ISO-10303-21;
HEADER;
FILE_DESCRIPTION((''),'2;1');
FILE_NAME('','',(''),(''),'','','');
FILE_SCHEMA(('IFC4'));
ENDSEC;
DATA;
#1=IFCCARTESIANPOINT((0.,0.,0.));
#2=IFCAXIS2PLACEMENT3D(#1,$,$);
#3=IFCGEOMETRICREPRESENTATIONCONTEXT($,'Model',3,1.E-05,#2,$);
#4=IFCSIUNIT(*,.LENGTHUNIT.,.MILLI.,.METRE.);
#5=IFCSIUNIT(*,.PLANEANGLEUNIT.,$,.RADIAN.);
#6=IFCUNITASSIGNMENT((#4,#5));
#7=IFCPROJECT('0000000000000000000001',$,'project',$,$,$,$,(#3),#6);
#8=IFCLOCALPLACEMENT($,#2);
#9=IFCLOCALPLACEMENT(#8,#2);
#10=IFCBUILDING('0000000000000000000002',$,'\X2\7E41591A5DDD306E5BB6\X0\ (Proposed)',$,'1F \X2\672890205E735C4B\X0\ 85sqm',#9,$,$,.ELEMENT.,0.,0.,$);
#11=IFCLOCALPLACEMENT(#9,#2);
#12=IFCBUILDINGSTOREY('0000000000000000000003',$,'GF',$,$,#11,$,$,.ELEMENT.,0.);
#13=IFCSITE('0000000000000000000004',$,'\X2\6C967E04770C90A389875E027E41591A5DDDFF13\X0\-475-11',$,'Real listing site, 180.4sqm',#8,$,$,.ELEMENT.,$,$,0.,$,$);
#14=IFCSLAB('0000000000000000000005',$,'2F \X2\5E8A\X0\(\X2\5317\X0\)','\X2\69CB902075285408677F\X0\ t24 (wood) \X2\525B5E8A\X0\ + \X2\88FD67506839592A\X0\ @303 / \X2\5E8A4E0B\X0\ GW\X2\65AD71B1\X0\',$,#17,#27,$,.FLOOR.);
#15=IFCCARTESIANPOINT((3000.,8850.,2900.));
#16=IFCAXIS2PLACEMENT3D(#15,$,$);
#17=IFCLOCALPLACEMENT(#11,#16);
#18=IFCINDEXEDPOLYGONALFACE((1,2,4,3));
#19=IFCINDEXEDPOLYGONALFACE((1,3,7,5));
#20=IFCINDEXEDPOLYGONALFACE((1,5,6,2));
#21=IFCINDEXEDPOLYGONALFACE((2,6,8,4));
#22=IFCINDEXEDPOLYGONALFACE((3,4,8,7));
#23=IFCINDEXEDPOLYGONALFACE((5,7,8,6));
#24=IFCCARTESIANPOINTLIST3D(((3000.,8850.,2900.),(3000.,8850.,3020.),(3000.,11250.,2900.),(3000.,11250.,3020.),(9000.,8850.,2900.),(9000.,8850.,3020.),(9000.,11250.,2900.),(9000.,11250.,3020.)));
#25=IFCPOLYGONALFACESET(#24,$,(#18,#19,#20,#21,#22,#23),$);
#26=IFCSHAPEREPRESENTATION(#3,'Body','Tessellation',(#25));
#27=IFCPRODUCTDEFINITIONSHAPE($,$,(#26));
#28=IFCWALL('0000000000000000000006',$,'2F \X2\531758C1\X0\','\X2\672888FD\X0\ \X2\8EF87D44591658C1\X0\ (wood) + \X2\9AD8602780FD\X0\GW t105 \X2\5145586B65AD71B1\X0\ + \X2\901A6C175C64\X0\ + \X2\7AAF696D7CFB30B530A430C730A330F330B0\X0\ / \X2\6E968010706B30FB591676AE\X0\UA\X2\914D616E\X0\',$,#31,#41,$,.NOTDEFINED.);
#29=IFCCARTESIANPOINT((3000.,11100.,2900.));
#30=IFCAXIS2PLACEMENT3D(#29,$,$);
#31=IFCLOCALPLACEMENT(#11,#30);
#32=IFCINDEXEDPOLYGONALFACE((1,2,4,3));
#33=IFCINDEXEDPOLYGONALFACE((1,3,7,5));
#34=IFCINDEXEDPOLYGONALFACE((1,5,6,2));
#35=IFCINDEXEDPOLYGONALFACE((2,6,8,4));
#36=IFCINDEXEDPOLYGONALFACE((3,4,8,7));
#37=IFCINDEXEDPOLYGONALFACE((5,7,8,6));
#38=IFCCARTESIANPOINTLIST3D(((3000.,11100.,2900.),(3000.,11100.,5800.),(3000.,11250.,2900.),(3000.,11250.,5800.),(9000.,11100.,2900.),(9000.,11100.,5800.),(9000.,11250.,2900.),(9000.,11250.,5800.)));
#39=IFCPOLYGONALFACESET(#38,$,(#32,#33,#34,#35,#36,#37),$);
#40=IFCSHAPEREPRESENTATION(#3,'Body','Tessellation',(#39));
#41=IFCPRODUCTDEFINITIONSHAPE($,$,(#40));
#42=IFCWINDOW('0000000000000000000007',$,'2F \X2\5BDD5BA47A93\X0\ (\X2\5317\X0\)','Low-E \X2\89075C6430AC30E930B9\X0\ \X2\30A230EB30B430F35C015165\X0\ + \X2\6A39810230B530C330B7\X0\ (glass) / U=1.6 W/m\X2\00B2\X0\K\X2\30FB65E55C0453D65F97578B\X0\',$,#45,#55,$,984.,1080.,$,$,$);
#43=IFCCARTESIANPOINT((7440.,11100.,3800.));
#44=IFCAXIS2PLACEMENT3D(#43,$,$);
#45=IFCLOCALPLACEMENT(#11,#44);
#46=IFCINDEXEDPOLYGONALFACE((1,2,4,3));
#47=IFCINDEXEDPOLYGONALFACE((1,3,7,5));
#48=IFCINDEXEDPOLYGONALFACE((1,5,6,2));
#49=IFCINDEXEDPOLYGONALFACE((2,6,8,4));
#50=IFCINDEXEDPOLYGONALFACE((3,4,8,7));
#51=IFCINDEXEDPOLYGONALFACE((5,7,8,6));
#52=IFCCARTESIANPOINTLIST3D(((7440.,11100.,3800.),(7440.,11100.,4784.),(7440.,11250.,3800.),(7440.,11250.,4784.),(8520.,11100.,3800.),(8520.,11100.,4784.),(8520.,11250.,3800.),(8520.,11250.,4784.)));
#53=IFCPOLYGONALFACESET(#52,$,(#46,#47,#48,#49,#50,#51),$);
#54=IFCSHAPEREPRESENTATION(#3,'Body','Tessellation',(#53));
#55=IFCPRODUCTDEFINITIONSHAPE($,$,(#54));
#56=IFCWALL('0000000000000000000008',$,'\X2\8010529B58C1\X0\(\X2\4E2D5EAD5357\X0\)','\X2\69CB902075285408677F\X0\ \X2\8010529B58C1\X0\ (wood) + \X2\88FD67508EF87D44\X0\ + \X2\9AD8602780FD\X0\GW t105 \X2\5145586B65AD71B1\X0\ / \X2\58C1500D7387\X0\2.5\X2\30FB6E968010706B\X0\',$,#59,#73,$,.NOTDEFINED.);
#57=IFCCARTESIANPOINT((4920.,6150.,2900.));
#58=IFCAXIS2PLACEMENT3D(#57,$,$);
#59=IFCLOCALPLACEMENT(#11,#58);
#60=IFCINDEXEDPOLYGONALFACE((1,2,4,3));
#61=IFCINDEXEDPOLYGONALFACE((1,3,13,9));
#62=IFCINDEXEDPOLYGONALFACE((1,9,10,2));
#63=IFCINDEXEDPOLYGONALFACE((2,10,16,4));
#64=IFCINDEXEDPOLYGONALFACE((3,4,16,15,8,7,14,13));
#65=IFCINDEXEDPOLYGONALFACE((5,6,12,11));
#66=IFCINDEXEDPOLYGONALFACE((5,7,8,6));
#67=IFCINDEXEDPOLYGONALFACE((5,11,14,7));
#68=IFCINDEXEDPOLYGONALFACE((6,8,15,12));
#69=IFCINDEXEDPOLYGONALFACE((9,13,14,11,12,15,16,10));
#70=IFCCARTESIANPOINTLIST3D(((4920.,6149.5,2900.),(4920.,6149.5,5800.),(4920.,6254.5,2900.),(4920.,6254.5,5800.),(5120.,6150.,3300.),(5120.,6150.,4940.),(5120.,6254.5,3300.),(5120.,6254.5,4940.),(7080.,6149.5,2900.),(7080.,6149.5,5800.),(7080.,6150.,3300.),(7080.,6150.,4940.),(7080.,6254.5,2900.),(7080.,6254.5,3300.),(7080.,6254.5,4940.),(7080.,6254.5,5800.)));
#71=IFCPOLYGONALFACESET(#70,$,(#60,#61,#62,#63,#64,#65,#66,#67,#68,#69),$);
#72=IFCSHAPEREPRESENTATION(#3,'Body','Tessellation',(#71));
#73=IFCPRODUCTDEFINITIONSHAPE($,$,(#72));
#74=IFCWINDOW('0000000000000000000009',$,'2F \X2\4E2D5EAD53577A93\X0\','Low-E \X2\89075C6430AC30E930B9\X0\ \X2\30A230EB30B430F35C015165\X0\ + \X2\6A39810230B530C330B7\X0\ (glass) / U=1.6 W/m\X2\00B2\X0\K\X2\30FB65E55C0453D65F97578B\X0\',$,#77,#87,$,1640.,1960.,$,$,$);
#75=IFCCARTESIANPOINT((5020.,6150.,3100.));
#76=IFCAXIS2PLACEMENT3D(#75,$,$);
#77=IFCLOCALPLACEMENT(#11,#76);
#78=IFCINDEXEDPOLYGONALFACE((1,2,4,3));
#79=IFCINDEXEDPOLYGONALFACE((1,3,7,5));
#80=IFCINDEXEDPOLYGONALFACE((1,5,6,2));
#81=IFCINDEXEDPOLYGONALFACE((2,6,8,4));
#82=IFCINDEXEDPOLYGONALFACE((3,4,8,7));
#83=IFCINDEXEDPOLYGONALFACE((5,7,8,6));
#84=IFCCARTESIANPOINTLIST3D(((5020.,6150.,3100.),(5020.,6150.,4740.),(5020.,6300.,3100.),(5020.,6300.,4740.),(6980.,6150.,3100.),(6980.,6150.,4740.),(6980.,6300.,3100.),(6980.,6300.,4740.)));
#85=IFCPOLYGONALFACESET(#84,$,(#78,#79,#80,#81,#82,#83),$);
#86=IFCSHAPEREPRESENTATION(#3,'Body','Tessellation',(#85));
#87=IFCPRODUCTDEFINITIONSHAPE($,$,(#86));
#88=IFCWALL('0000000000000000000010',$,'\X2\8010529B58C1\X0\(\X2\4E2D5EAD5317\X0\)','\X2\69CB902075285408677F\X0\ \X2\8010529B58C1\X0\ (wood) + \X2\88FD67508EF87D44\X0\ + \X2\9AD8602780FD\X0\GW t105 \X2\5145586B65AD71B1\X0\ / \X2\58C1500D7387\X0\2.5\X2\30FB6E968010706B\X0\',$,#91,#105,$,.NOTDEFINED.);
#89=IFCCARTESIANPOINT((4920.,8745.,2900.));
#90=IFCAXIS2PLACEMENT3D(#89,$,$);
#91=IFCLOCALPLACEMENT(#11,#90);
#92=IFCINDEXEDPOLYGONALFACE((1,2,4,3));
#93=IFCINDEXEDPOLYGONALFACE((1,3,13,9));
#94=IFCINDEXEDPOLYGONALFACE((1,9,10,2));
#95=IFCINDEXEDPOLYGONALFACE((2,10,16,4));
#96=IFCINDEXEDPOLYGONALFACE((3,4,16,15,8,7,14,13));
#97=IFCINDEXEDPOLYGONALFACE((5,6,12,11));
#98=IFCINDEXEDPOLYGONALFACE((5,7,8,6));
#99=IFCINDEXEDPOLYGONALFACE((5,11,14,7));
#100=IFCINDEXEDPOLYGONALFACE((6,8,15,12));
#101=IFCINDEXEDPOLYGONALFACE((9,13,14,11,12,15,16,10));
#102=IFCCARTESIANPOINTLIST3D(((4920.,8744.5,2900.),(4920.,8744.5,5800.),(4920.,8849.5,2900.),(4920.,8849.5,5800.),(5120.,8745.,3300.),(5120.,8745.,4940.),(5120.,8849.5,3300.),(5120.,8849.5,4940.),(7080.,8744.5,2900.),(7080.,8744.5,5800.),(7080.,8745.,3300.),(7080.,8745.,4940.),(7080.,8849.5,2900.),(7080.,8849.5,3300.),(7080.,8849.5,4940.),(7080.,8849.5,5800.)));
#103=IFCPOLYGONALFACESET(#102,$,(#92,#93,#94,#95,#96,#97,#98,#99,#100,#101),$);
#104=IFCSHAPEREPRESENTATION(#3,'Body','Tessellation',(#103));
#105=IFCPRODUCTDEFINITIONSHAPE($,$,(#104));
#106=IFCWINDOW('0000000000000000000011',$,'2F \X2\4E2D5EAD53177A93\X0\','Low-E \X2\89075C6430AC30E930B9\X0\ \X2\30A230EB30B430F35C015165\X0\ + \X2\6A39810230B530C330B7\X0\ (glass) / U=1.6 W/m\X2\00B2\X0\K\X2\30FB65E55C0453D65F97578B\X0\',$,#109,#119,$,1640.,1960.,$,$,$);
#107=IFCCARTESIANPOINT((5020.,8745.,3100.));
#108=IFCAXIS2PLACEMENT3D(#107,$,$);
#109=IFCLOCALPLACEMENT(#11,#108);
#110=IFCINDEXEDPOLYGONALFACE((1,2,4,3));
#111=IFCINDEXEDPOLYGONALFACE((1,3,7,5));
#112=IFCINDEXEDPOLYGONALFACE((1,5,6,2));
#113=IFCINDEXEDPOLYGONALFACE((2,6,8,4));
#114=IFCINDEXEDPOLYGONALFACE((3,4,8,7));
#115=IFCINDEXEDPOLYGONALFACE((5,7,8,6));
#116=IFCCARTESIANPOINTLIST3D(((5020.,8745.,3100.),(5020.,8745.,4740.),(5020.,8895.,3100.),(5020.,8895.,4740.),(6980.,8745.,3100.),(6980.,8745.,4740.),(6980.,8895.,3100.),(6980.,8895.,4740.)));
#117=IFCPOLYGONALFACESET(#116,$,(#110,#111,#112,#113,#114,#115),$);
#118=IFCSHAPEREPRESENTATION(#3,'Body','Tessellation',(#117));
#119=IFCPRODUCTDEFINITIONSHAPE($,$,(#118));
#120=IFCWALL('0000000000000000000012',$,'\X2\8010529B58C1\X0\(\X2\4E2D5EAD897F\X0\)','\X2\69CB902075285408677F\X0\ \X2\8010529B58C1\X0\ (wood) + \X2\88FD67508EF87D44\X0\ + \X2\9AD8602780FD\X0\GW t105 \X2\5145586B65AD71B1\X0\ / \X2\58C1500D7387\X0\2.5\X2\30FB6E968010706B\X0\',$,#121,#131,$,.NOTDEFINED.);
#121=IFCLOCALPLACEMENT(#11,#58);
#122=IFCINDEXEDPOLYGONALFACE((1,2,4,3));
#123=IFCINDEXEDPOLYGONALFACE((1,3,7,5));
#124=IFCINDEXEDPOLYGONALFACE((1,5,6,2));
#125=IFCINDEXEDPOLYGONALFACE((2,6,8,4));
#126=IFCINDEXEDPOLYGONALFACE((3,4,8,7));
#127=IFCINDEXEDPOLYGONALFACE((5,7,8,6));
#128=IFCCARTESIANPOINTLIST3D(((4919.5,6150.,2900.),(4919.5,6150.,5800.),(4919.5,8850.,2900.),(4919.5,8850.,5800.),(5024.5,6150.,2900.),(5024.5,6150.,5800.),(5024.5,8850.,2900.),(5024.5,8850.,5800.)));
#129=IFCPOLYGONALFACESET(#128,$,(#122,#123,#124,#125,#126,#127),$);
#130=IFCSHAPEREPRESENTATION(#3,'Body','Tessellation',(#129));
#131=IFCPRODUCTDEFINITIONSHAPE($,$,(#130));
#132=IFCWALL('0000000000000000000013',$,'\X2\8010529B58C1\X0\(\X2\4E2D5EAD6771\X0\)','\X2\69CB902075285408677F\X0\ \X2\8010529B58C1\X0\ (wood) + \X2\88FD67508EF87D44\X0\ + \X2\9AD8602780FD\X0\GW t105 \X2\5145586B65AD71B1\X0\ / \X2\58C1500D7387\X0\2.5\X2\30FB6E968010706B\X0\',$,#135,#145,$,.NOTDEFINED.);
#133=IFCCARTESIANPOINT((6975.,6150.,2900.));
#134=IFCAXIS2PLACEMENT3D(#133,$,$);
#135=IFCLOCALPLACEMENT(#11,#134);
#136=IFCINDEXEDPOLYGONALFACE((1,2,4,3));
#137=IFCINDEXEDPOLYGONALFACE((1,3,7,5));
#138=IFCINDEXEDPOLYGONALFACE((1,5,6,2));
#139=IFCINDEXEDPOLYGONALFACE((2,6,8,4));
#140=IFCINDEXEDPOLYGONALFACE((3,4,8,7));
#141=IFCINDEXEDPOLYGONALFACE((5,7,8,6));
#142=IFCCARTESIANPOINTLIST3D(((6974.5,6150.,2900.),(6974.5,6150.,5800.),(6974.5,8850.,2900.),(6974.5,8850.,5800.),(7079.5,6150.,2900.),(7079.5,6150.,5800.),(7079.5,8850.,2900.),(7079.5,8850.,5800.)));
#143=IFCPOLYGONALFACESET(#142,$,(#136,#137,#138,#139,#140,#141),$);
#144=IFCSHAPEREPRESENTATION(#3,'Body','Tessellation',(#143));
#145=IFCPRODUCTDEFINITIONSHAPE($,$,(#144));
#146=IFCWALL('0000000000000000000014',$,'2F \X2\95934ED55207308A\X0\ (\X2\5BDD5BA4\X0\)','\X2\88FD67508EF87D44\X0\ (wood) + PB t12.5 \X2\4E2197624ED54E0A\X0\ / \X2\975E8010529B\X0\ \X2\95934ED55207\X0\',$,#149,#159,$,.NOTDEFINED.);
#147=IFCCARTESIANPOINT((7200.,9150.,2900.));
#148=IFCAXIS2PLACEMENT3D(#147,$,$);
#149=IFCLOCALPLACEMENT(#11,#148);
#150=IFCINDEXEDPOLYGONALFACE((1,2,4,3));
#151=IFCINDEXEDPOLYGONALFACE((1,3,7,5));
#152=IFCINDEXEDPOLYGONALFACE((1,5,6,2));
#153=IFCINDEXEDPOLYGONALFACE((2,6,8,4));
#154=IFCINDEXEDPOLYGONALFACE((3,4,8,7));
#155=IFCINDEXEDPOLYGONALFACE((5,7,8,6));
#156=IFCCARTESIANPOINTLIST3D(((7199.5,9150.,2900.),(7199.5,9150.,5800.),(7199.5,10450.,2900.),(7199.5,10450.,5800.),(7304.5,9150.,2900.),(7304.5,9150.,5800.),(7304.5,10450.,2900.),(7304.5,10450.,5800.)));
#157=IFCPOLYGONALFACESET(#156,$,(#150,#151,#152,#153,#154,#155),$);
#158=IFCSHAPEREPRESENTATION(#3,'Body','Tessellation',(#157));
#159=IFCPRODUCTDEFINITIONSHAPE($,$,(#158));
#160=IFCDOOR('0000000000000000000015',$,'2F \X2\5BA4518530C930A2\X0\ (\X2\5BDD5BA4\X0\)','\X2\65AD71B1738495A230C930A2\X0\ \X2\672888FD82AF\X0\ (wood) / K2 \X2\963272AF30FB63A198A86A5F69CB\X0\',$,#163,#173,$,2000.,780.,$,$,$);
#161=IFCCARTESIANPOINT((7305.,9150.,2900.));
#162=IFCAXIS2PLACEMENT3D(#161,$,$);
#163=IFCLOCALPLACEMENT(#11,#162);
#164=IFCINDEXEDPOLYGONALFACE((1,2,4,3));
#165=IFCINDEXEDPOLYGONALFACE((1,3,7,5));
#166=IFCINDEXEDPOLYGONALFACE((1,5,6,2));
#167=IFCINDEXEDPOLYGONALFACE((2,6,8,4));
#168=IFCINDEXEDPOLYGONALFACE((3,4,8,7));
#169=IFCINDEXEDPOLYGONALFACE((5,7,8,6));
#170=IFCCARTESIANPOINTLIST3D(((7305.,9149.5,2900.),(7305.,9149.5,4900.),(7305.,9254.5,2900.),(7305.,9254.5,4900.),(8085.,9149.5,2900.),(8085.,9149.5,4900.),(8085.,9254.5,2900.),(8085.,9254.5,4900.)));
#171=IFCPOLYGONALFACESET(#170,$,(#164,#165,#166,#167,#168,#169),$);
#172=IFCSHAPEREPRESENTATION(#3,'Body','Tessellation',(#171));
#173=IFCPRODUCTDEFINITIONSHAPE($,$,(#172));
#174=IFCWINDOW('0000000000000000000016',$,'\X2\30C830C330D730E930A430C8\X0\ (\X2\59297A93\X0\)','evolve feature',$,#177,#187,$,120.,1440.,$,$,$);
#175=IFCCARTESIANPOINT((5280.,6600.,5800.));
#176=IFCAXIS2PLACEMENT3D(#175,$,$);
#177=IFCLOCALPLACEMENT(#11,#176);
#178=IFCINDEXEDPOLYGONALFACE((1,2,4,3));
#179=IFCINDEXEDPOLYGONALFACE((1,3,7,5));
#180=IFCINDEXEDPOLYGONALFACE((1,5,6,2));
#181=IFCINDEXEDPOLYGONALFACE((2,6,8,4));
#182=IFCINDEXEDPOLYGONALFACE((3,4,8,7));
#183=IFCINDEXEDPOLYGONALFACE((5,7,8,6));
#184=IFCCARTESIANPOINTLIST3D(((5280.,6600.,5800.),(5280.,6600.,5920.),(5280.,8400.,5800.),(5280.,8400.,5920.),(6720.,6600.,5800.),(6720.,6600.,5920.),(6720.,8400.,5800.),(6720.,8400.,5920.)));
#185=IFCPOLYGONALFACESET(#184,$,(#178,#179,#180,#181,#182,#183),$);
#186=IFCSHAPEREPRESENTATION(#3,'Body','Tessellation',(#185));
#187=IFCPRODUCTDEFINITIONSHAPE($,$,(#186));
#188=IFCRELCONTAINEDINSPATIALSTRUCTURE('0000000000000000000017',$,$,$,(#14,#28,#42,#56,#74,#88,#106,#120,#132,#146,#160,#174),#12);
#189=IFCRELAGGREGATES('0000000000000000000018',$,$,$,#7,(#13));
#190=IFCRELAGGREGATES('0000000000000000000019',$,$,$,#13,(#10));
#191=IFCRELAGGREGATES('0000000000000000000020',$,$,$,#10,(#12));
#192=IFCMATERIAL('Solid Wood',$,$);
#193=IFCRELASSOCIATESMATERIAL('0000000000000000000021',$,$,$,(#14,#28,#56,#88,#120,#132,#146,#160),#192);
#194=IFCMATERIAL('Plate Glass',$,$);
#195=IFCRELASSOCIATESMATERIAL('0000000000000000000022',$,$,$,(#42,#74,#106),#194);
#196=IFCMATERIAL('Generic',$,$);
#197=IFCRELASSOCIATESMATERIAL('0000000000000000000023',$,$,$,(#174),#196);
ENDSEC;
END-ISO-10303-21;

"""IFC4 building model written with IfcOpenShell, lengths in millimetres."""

from ifc_helpers import new_model, si_unit, frame, frame_2d, origin, place, context, project, spatial, rectangle, extrude, material, element, fill, save


model = new_model("IFC4")

# Units and contexts
model_context = context("Model", 3, precision=1e-05, world=origin())
ifc_project = project(units=[si_unit("LENGTHUNIT", "METRE", prefix="MILLI"), si_unit("PLANEANGLEUNIT", "RADIAN")], contexts=[model_context])

# Site, building, storey
site_placement = place(None, origin())
site = spatial("IfcSite", under=ifc_project, at=site_placement, Name="沖縄県那覇市繁多川３-475-11", ObjectType="Real listing site, 180.4sqm", CompositionType="ELEMENT", RefElevation=0.0)
building_placement = place(site_placement, origin())
building = spatial("IfcBuilding", under=site, at=building_placement, Name="繁多川の家 (Proposed)", ObjectType="1F 木造平屋 85sqm", CompositionType="ELEMENT", ElevationOfRefHeight=0.0, ElevationOfTerrain=0.0)
storey_placement = place(building_placement, origin())
storey = spatial("IfcBuildingStorey", under=building, at=storey_placement, Name="GF", CompositionType="ELEMENT", Elevation=0.0)

# Slab
ifc_material_1 = material(Name="Solid Wood")
slab_placement = place(storey_placement, frame((3000.0, 8850.0, 2900.0)))
element("IfcSlab", 1, at=slab_placement, inside=storey, material=ifc_material_1, Name="2F 床(北)", Description="構造用合板 t24 (wood) 剛床 + 製材根太 @303 / 床下 GW断熱", PredefinedType="FLOOR", context=model_context, shape_type="SweptSolid", body=[
    extrude(rectangle(XDim=6000.0, YDim=2400.0, at=frame_2d((3000.0, 1200.0))), frame((3000.0, 8850.0, 2900.0)), (0.0, 0.0, 1.0), 120.0),
])

# Walls, openings, windows
wall_1_placement = place(storey_placement, frame((3000.0, 11100.0, 2900.0)))
wall_1 = element("IfcWall", 2, at=wall_1_placement, inside=storey, material=ifc_material_1, Name="2F 北壁", Description="木製 軸組外壁 (wood) + 高性能GW t105 充填断熱 + 通気層 + 窯業系サイディング / 準耐火・外皮UA配慮", PredefinedType="NOTDEFINED", context=model_context, shape_type="SweptSolid", body=[
    extrude(rectangle(XDim=6000.0, YDim=150.0, at=frame_2d((3000.0, 75.0))), frame((3000.0, 11100.0, 2900.0)), (0.0, 0.0, 1.0), 2900.0),
])
opening_1_placement = place(storey_placement, frame((7440.0, 11100.0, 3800.0)))
opening_1 = element("IfcOpeningElement", 3, at=opening_1_placement, cuts=wall_1, PredefinedType="NOTDEFINED", context=model_context, shape_type="SweptSolid", body=[
    extrude(rectangle(XDim=1080.0, YDim=150.0, at=frame_2d((540.0, 75.0))), frame((7440.0, 11100.0, 3800.0)), (0.0, 0.0, 1.0), 984.0),
])
ifc_material_2 = material(Name="Plate Glass")
window_1_placement = place(storey_placement, frame((7440.0, 11100.0, 3800.0)))
window_1 = element("IfcWindow", 4, at=window_1_placement, inside=storey, material=ifc_material_2, Name="2F 寝室窓 (北)", Description="Low-E 複層ガラス アルゴン封入 + 樹脂サッシ (glass) / U=1.6 W/m²K・日射取得型", OverallHeight=984.0, OverallWidth=1080.0, context=model_context, shape_type="SweptSolid", body=[
    extrude(rectangle(XDim=1080.0, YDim=150.0, at=frame_2d((540.0, 75.0))), frame((7440.0, 11100.0, 3800.0)), (0.0, 0.0, 1.0), 984.0),
])
fill(opening_1, window_1)
wall_2_placement = place(storey_placement, frame((4920.0, 6150.0, 2900.0)))
wall_2 = element("IfcWall", 5, at=wall_2_placement, inside=storey, material=ifc_material_1, Name="耐力壁(中庭南)", Description="構造用合板 耐力壁 (wood) + 製材軸組 + 高性能GW t105 充填断熱 / 壁倍率2.5・準耐火", PredefinedType="NOTDEFINED", context=model_context, shape_type="SweptSolid", body=[
    extrude(rectangle(XDim=2160.0, YDim=105.0, at=frame_2d((1080.0, 52.0))), frame((4920.0, 6150.0, 2900.0)), (0.0, 0.0, 1.0), 2900.0),
])
opening_2_placement = place(storey_placement, frame((5020.0, 6150.0, 3100.0)))
opening_2 = element("IfcOpeningElement", 6, at=opening_2_placement, cuts=wall_2, PredefinedType="NOTDEFINED", context=model_context, shape_type="SweptSolid", body=[
    extrude(rectangle(XDim=1960.0, YDim=150.0, at=frame_2d((980.0, 75.0))), frame((5020.0, 6150.0, 3100.0)), (0.0, 0.0, 1.0), 1640.0),
])
window_2_placement = place(storey_placement, frame((5020.0, 6150.0, 3100.0)))
window_2 = element("IfcWindow", 7, at=window_2_placement, inside=storey, material=ifc_material_2, Name="2F 中庭南窓", Description="Low-E 複層ガラス アルゴン封入 + 樹脂サッシ (glass) / U=1.6 W/m²K・日射取得型", OverallHeight=1640.0, OverallWidth=1960.0, context=model_context, shape_type="SweptSolid", body=[
    extrude(rectangle(XDim=1960.0, YDim=150.0, at=frame_2d((980.0, 75.0))), frame((5020.0, 6150.0, 3100.0)), (0.0, 0.0, 1.0), 1640.0),
])
fill(opening_2, window_2)
wall_3_placement = place(storey_placement, frame((4920.0, 8745.0, 2900.0)))
wall_3 = element("IfcWall", 8, at=wall_3_placement, inside=storey, material=ifc_material_1, Name="耐力壁(中庭北)", Description="構造用合板 耐力壁 (wood) + 製材軸組 + 高性能GW t105 充填断熱 / 壁倍率2.5・準耐火", PredefinedType="NOTDEFINED", context=model_context, shape_type="SweptSolid", body=[
    extrude(rectangle(XDim=2160.0, YDim=105.0, at=frame_2d((1080.0, 52.0))), frame((4920.0, 8745.0, 2900.0)), (0.0, 0.0, 1.0), 2900.0),
])
opening_3_placement = place(storey_placement, frame((5020.0, 8745.0, 3100.0)))
opening_3 = element("IfcOpeningElement", 9, at=opening_3_placement, cuts=wall_3, PredefinedType="NOTDEFINED", context=model_context, shape_type="SweptSolid", body=[
    extrude(rectangle(XDim=1960.0, YDim=150.0, at=frame_2d((980.0, 75.0))), frame((5020.0, 8745.0, 3100.0)), (0.0, 0.0, 1.0), 1640.0),
])
window_3_placement = place(storey_placement, frame((5020.0, 8745.0, 3100.0)))
window_3 = element("IfcWindow", 10, at=window_3_placement, inside=storey, material=ifc_material_2, Name="2F 中庭北窓", Description="Low-E 複層ガラス アルゴン封入 + 樹脂サッシ (glass) / U=1.6 W/m²K・日射取得型", OverallHeight=1640.0, OverallWidth=1960.0, context=model_context, shape_type="SweptSolid", body=[
    extrude(rectangle(XDim=1960.0, YDim=150.0, at=frame_2d((980.0, 75.0))), frame((5020.0, 8745.0, 3100.0)), (0.0, 0.0, 1.0), 1640.0),
])
fill(opening_3, window_3)

# Walls
wall_4_placement = place(storey_placement, frame((4920.0, 6150.0, 2900.0)))
element("IfcWall", 11, at=wall_4_placement, inside=storey, material=ifc_material_1, Name="耐力壁(中庭西)", Description="構造用合板 耐力壁 (wood) + 製材軸組 + 高性能GW t105 充填断熱 / 壁倍率2.5・準耐火", PredefinedType="NOTDEFINED", context=model_context, shape_type="SweptSolid", body=[
    extrude(rectangle(XDim=105.0, YDim=2700.0, at=frame_2d((52.0, 1350.0))), frame((4920.0, 6150.0, 2900.0)), (0.0, 0.0, 1.0), 2900.0),
])
wall_5_placement = place(storey_placement, frame((6975.0, 6150.0, 2900.0)))
element("IfcWall", 12, at=wall_5_placement, inside=storey, material=ifc_material_1, Name="耐力壁(中庭東)", Description="構造用合板 耐力壁 (wood) + 製材軸組 + 高性能GW t105 充填断熱 / 壁倍率2.5・準耐火", PredefinedType="NOTDEFINED", context=model_context, shape_type="SweptSolid", body=[
    extrude(rectangle(XDim=105.0, YDim=2700.0, at=frame_2d((52.0, 1350.0))), frame((6975.0, 6150.0, 2900.0)), (0.0, 0.0, 1.0), 2900.0),
])
wall_6_placement = place(storey_placement, frame((7200.0, 9150.0, 2900.0)))
element("IfcWall", 13, at=wall_6_placement, inside=storey, material=ifc_material_1, Name="2F 間仕切り (寝室)", Description="製材軸組 (wood) + PB t12.5 両面仕上 / 非耐力 間仕切", PredefinedType="NOTDEFINED", context=model_context, shape_type="SweptSolid", body=[
    extrude(rectangle(XDim=105.0, YDim=1300.0, at=frame_2d((52.0, 650.0))), frame((7200.0, 9150.0, 2900.0)), (0.0, 0.0, 1.0), 2900.0),
])

# Door
door_placement = place(storey_placement, frame((7305.0, 9150.0, 2900.0)))
element("IfcDoor", 14, at=door_placement, inside=storey, material=ifc_material_1, Name="2F 室内ドア (寝室)", Description="断熱玄関ドア 木製芯 (wood) / K2 防犯・採風機構", OverallHeight=2000.0, OverallWidth=780.0, context=model_context, shape_type="SweptSolid", body=[
    extrude(rectangle(XDim=780.0, YDim=105.0, at=frame_2d((390.0, 52.0))), frame((7305.0, 9150.0, 2900.0)), (0.0, 0.0, 1.0), 2000.0),
])

# Window
ifc_material_3 = material(Name="Generic")
window_4_placement = place(storey_placement, frame((5280.0, 6600.0, 5800.0)))
element("IfcWindow", 15, at=window_4_placement, inside=storey, material=ifc_material_3, Name="トップライト (天窓)", Description="evolve feature", OverallHeight=120.0, OverallWidth=1440.0, context=model_context, shape_type="SweptSolid", body=[
    extrude(rectangle(XDim=1440.0, YDim=1800.0, at=frame_2d((720.0, 900.0))), frame((5280.0, 6600.0, 5800.0)), (0.0, 0.0, 1.0), 120.0),
])

save(model, "model.ifc")
